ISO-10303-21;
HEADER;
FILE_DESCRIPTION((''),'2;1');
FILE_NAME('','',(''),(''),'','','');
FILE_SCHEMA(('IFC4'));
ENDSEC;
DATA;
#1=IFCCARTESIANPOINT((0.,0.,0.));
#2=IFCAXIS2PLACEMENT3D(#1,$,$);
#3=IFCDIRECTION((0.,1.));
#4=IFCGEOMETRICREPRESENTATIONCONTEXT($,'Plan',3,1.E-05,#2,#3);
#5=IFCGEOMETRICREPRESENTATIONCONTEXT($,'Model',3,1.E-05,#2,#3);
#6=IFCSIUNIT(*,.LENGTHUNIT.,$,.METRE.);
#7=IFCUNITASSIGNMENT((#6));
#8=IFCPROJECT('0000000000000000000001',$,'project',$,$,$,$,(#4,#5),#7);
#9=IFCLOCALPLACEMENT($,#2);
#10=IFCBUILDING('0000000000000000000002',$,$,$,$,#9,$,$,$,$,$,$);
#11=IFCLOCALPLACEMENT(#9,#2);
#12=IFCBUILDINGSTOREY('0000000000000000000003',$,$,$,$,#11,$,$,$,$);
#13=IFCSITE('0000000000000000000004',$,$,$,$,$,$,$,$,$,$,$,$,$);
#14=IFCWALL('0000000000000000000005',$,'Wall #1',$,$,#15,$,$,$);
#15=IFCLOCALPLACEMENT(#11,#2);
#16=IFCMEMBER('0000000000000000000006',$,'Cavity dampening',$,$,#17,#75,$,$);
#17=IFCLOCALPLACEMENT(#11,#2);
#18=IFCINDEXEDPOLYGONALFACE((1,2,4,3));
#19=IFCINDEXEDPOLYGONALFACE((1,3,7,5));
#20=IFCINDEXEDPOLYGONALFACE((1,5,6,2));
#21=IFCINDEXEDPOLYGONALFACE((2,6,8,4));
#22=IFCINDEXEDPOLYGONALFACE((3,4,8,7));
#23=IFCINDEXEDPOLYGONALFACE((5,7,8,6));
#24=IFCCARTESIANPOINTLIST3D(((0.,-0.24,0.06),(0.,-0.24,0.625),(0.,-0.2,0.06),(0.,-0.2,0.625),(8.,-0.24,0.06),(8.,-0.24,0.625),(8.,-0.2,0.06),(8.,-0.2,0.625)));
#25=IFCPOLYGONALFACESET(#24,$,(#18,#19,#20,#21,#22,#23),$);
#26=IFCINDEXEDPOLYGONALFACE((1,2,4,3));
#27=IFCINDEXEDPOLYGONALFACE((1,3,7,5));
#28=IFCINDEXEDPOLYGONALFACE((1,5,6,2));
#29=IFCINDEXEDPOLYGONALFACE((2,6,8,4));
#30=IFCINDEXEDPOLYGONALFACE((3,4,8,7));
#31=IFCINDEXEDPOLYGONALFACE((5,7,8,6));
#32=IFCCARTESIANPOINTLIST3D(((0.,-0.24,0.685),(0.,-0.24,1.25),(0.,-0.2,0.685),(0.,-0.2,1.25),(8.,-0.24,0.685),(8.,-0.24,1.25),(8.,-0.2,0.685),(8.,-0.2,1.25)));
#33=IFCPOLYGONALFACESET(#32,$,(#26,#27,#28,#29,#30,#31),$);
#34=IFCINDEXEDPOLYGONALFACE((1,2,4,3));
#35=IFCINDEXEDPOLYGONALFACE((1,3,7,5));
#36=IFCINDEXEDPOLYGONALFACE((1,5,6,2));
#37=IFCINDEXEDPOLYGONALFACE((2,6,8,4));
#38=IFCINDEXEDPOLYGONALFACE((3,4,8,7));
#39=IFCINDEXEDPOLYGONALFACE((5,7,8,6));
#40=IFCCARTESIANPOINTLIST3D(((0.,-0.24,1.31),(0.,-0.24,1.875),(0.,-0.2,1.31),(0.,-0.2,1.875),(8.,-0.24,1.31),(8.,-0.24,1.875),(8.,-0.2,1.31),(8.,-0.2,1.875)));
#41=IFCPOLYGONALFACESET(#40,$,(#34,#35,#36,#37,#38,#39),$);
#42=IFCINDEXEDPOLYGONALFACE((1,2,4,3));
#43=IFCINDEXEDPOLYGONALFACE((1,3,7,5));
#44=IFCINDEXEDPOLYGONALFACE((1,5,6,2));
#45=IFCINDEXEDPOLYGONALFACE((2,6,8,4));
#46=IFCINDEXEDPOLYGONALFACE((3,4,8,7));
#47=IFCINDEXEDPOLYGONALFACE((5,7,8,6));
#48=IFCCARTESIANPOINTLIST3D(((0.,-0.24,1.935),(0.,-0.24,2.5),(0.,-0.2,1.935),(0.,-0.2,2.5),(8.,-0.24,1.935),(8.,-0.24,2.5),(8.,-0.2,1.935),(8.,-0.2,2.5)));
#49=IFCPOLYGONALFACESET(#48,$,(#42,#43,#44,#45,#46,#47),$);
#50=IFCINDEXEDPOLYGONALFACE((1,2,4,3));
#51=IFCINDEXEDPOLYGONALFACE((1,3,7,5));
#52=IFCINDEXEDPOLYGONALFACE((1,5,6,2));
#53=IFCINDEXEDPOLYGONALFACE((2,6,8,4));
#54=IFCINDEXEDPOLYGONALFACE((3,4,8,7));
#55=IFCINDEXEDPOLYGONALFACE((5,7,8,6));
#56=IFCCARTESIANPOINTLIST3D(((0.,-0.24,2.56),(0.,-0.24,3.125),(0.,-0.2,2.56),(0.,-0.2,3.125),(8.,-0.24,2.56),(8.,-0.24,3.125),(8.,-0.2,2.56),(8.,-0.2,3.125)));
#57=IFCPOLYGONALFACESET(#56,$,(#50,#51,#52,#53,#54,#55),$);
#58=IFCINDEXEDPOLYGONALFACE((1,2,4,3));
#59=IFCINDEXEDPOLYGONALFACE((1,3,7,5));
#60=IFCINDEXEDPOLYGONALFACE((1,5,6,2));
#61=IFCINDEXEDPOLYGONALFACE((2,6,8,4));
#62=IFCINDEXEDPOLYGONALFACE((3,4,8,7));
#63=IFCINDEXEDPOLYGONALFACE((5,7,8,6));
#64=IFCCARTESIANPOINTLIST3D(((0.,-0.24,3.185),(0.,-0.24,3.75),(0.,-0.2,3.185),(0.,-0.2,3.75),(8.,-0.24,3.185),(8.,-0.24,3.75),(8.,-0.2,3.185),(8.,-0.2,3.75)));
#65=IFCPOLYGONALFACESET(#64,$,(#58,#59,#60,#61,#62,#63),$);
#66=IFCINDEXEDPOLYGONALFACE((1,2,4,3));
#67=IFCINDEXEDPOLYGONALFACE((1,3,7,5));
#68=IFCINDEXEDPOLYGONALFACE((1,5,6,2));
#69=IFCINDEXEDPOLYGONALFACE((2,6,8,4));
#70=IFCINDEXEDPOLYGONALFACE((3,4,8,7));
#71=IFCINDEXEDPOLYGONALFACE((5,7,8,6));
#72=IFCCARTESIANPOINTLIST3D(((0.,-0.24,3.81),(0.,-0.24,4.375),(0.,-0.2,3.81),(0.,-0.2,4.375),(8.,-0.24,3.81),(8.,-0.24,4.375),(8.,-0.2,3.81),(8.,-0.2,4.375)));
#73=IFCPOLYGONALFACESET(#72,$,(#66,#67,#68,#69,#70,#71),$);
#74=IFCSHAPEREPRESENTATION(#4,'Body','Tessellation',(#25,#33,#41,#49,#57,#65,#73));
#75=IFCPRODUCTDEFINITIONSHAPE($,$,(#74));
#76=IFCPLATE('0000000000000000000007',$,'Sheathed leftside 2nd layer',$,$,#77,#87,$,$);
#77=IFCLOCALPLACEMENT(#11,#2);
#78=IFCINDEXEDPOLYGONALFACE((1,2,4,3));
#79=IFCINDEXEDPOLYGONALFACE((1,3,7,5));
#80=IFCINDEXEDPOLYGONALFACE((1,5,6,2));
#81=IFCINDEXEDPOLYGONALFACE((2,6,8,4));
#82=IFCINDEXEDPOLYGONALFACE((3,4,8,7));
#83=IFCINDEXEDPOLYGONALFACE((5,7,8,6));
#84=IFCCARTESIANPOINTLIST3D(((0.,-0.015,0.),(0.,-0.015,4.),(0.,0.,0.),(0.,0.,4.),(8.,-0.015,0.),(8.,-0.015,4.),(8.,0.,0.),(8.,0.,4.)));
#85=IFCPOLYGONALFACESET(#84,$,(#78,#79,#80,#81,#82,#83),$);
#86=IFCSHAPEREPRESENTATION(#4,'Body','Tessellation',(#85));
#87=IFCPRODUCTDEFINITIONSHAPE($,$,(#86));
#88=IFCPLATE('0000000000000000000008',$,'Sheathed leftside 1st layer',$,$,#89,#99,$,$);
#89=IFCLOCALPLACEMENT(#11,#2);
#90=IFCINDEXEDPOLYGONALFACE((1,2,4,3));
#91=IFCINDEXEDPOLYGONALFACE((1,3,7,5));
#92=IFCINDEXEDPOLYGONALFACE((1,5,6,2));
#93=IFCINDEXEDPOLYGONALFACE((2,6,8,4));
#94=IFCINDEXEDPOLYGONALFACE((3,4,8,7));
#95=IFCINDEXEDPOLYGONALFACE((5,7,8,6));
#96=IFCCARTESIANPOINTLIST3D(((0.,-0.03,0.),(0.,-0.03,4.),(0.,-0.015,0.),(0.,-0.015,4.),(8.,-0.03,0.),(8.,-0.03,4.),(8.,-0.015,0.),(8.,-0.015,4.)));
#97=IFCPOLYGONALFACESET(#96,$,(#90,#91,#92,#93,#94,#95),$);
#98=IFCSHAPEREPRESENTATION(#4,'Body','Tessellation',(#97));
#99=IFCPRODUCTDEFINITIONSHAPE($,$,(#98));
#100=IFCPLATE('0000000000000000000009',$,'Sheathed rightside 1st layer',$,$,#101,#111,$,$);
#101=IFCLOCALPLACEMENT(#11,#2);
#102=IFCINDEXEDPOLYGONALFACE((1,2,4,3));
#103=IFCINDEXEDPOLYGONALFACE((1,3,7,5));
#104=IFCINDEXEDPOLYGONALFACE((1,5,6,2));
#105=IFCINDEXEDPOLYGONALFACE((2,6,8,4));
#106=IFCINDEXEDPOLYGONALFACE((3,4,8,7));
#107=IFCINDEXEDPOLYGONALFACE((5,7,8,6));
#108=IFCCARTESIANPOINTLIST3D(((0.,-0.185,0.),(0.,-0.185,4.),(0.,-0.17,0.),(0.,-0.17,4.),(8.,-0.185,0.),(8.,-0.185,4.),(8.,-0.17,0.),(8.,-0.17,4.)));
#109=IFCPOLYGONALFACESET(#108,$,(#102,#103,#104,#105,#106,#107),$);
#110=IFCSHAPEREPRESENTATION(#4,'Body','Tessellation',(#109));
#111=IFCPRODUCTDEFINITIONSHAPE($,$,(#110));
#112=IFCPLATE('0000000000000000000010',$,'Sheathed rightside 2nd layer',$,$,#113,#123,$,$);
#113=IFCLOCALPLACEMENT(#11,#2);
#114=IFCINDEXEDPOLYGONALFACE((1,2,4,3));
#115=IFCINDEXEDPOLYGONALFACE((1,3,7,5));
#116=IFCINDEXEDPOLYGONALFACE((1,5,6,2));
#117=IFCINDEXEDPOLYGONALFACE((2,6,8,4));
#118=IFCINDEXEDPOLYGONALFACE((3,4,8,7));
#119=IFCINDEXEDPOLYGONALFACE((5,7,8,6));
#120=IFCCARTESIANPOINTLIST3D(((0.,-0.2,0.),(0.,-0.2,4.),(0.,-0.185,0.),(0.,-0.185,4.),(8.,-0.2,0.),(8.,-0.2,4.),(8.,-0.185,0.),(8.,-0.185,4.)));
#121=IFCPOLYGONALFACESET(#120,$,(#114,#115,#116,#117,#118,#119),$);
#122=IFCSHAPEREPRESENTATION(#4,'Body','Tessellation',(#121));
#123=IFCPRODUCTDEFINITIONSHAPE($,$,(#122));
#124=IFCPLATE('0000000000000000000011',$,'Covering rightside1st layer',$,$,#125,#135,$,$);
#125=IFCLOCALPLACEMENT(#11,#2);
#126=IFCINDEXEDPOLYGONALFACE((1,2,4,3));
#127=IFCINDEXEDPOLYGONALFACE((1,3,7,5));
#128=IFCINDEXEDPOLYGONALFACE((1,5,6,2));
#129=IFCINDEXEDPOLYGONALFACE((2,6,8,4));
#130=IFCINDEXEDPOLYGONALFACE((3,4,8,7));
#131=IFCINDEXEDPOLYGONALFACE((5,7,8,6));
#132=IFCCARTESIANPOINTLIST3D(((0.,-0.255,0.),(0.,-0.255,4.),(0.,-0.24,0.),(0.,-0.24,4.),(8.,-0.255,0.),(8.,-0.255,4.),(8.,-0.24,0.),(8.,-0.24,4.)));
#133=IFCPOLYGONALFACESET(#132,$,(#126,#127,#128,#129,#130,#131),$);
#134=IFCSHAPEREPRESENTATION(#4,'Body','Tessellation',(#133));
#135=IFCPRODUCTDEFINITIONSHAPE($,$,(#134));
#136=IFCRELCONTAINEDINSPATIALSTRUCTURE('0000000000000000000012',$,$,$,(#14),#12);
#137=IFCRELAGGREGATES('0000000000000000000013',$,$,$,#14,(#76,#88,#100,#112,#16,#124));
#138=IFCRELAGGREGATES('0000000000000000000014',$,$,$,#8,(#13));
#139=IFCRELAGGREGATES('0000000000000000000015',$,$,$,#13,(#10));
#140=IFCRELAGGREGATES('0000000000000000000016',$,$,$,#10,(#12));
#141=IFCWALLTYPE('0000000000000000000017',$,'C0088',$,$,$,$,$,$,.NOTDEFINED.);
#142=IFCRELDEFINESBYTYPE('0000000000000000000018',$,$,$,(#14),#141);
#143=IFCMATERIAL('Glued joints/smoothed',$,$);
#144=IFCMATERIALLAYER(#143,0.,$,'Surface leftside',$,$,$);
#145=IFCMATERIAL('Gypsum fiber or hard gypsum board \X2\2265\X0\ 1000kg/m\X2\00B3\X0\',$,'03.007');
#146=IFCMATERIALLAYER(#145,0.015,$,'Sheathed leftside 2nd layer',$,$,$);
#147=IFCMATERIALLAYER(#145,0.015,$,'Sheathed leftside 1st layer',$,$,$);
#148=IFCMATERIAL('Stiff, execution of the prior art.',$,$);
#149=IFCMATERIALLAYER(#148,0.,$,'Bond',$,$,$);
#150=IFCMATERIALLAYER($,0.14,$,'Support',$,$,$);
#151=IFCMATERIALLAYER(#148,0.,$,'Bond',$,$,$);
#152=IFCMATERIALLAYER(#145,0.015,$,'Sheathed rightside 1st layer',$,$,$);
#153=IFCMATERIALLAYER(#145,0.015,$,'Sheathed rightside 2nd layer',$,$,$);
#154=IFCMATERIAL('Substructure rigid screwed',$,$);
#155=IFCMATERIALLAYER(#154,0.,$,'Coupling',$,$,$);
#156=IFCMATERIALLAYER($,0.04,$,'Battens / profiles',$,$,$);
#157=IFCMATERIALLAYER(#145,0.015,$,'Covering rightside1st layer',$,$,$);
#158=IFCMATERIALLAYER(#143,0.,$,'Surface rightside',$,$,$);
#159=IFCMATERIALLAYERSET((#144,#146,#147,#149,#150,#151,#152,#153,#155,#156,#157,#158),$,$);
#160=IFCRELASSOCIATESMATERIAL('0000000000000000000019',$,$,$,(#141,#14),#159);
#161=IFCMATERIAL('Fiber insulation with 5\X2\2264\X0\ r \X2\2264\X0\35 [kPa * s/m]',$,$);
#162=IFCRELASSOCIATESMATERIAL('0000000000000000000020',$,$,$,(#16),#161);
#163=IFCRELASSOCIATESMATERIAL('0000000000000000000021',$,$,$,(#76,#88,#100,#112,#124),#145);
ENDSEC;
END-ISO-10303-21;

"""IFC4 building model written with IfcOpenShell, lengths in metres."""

from ifc_helpers import new_model, si_unit, direction, frame, frame_2d, origin, origin_with_axes, place, context, project, spatial, rectangle, extrude, material, layer, layer_set, type_object, element, aggregate, save


model = new_model("IFC4")

# Units and contexts
plan_context = context("Plan", 3, precision=1e-05, world=origin(), true_north=direction((0.0, 1.0)))
model_context = context("Model", 3, precision=1e-05, world=origin(), true_north=direction((0.0, 1.0)))
ifc_project = project(units=[si_unit("LENGTHUNIT", "METRE")], contexts=[plan_context, model_context])

# Site, building, storey
site = spatial("IfcSite", under=ifc_project)
building_placement = place(None, origin())
building = spatial("IfcBuilding", under=site, at=building_placement)
storey_placement = place(building_placement, origin())
storey = spatial("IfcBuildingStorey", under=building, at=storey_placement)

# Wall, member, plates
ifc_material_1 = material(Name="Glued joints/smoothed")
ifc_layer_1 = layer(ifc_material_1, 0.0, Name="Surface leftside")
ifc_material_2 = material(Name="Gypsum fiber or hard gypsum board ≥ 1000kg/m³", Category="03.007")
ifc_layer_2 = layer(ifc_material_2, 0.015, Name="Sheathed leftside 2nd layer")
ifc_layer_3 = layer(ifc_material_2, 0.015, Name="Sheathed leftside 1st layer")
ifc_material_3 = material(Name="Stiff, execution of the prior art.")
ifc_layer_4 = layer(ifc_material_3, 0.0, Name="Bond")
ifc_layer_5 = layer(None, 0.14, Name="Support")
ifc_layer_6 = layer(ifc_material_3, 0.0, Name="Bond")
ifc_layer_7 = layer(ifc_material_2, 0.015, Name="Sheathed rightside 1st layer")
ifc_layer_8 = layer(ifc_material_2, 0.015, Name="Sheathed rightside 2nd layer")
ifc_material_4 = material(Name="Substructure rigid screwed")
ifc_layer_9 = layer(ifc_material_4, 0.0, Name="Coupling")
ifc_layer_10 = layer(None, 0.04, Name="Battens / profiles")
ifc_layer_11 = layer(ifc_material_2, 0.015, Name="Covering rightside1st layer")
ifc_layer_12 = layer(ifc_material_1, 0.0, Name="Surface rightside")
ifc_layer_set = layer_set([ifc_layer_1, ifc_layer_2, ifc_layer_3, ifc_layer_4, ifc_layer_5, ifc_layer_6, ifc_layer_7, ifc_layer_8, ifc_layer_9, ifc_layer_10, ifc_layer_11, ifc_layer_12])
wall_type = type_object("IfcWallType", Name="C0088", PredefinedType="NOTDEFINED", material=ifc_layer_set)
wall_placement = place(None, frame((0.0, 0.0, 0.0), z_axis=(0.0, -1.0, 0.0), x_axis=(1.0, 0.0, 0.0)))
wall = element("IfcWall", 1, at=wall_placement, inside=storey, type_object=wall_type, material=ifc_layer_set, Name="Wall #1")
ifc_material_5 = material(Name="Fiber insulation with 5≤ r ≤35 [kPa * s/m]")
member_1_placement = place(wall_placement, origin())
member_1 = element("IfcMember", 2, at=member_1_placement, material=ifc_material_5, Name="Cavity dampening", context=plan_context, shape_type="SweptSolid", body=[
    extrude(rectangle(XDim=0.565, YDim=0.04, at=frame_2d((0.2825, 0.02), x_axis=(1.0, 0.0))), frame((0.0, 0.06, 0.2), z_axis=(1.0, 0.0, 0.0), x_axis=(0.0, 1.0, 0.0)), (0.0, 0.0, 1.0), 8.0),
    extrude(rectangle(XDim=0.565, YDim=0.04, at=frame_2d((0.2825, 0.02), x_axis=(1.0, 0.0))), frame((0.0, 0.685, 0.2), z_axis=(1.0, 0.0, 0.0), x_axis=(0.0, 1.0, 0.0)), (0.0, 0.0, 1.0), 8.0),
    extrude(rectangle(XDim=0.565, YDim=0.04, at=frame_2d((0.2825, 0.02), x_axis=(1.0, 0.0))), frame((0.0, 1.31, 0.2), z_axis=(1.0, 0.0, 0.0), x_axis=(0.0, 1.0, 0.0)), (0.0, 0.0, 1.0), 8.0),
    extrude(rectangle(XDim=0.565, YDim=0.04, at=frame_2d((0.2825, 0.02), x_axis=(1.0, 0.0))), frame((0.0, 1.935, 0.2), z_axis=(1.0, 0.0, 0.0), x_axis=(0.0, 1.0, 0.0)), (0.0, 0.0, 1.0), 8.0),
    extrude(rectangle(XDim=0.565, YDim=0.04, at=frame_2d((0.2825, 0.02), x_axis=(1.0, 0.0))), frame((0.0, 2.56, 0.2), z_axis=(1.0, 0.0, 0.0), x_axis=(0.0, 1.0, 0.0)), (0.0, 0.0, 1.0), 8.0),
    extrude(rectangle(XDim=0.565, YDim=0.04, at=frame_2d((0.2825, 0.02), x_axis=(1.0, 0.0))), frame((0.0, 3.185, 0.2), z_axis=(1.0, 0.0, 0.0), x_axis=(0.0, 1.0, 0.0)), (0.0, 0.0, 1.0), 8.0),
    extrude(rectangle(XDim=0.565, YDim=0.04, at=frame_2d((0.2825, 0.02), x_axis=(1.0, 0.0))), frame((0.0, 3.81, 0.2), z_axis=(1.0, 0.0, 0.0), x_axis=(0.0, 1.0, 0.0)), (0.0, 0.0, 1.0), 8.0),
])
plate_1_placement = place(wall_placement, origin())
plate_1 = element("IfcPlate", 3, at=plate_1_placement, material=ifc_material_2, Name="Sheathed leftside 2nd layer", context=plan_context, shape_type="SweptSolid", body=[
    extrude(rectangle(XDim=8.0, YDim=4.0, at=frame_2d((4.0, 2.0), x_axis=(1.0, 0.0))), origin_with_axes(), (0.0, 0.0, 1.0), 0.015),
])
plate_2_placement = place(wall_placement, origin())
plate_2 = element("IfcPlate", 4, at=plate_2_placement, material=ifc_material_2, Name="Sheathed leftside 1st layer", context=plan_context, shape_type="SweptSolid", body=[
    extrude(rectangle(XDim=8.0, YDim=4.0, at=frame_2d((4.0, 2.0), x_axis=(1.0, 0.0))), frame((0.0, 0.0, 0.015), z_axis=(0.0, 0.0, 1.0), x_axis=(1.0, 0.0, 0.0)), (0.0, 0.0, 1.0), 0.015),
])
plate_3_placement = place(wall_placement, origin())
plate_3 = element("IfcPlate", 5, at=plate_3_placement, material=ifc_material_2, Name="Sheathed rightside 1st layer", context=plan_context, shape_type="SweptSolid", body=[
    extrude(rectangle(XDim=8.0, YDim=4.0, at=frame_2d((4.0, 2.0), x_axis=(1.0, 0.0))), frame((0.0, 0.0, 0.17), z_axis=(0.0, 0.0, 1.0), x_axis=(1.0, 0.0, 0.0)), (0.0, 0.0, 1.0), 0.015),
])
plate_4_placement = place(wall_placement, origin())
plate_4 = element("IfcPlate", 6, at=plate_4_placement, material=ifc_material_2, Name="Sheathed rightside 2nd layer", context=plan_context, shape_type="SweptSolid", body=[
    extrude(rectangle(XDim=8.0, YDim=4.0, at=frame_2d((4.0, 2.0), x_axis=(1.0, 0.0))), frame((0.0, 0.0, 0.185), z_axis=(0.0, 0.0, 1.0), x_axis=(1.0, 0.0, 0.0)), (0.0, 0.0, 1.0), 0.015),
])
plate_5_placement = place(wall_placement, origin())
plate_5 = element("IfcPlate", 7, at=plate_5_placement, material=ifc_material_2, Name="Covering rightside1st layer", context=plan_context, shape_type="SweptSolid", body=[
    extrude(rectangle(XDim=8.0, YDim=4.0, at=frame_2d((4.0, 2.0), x_axis=(1.0, 0.0))), frame((0.0, 0.0, 0.24), z_axis=(0.0, 0.0, 1.0), x_axis=(1.0, 0.0, 0.0)), (0.0, 0.0, 1.0), 0.015),
])
aggregate(wall, [plate_1, plate_2, plate_3, plate_4, member_1, plate_5])

save(model, "model.ifc")
